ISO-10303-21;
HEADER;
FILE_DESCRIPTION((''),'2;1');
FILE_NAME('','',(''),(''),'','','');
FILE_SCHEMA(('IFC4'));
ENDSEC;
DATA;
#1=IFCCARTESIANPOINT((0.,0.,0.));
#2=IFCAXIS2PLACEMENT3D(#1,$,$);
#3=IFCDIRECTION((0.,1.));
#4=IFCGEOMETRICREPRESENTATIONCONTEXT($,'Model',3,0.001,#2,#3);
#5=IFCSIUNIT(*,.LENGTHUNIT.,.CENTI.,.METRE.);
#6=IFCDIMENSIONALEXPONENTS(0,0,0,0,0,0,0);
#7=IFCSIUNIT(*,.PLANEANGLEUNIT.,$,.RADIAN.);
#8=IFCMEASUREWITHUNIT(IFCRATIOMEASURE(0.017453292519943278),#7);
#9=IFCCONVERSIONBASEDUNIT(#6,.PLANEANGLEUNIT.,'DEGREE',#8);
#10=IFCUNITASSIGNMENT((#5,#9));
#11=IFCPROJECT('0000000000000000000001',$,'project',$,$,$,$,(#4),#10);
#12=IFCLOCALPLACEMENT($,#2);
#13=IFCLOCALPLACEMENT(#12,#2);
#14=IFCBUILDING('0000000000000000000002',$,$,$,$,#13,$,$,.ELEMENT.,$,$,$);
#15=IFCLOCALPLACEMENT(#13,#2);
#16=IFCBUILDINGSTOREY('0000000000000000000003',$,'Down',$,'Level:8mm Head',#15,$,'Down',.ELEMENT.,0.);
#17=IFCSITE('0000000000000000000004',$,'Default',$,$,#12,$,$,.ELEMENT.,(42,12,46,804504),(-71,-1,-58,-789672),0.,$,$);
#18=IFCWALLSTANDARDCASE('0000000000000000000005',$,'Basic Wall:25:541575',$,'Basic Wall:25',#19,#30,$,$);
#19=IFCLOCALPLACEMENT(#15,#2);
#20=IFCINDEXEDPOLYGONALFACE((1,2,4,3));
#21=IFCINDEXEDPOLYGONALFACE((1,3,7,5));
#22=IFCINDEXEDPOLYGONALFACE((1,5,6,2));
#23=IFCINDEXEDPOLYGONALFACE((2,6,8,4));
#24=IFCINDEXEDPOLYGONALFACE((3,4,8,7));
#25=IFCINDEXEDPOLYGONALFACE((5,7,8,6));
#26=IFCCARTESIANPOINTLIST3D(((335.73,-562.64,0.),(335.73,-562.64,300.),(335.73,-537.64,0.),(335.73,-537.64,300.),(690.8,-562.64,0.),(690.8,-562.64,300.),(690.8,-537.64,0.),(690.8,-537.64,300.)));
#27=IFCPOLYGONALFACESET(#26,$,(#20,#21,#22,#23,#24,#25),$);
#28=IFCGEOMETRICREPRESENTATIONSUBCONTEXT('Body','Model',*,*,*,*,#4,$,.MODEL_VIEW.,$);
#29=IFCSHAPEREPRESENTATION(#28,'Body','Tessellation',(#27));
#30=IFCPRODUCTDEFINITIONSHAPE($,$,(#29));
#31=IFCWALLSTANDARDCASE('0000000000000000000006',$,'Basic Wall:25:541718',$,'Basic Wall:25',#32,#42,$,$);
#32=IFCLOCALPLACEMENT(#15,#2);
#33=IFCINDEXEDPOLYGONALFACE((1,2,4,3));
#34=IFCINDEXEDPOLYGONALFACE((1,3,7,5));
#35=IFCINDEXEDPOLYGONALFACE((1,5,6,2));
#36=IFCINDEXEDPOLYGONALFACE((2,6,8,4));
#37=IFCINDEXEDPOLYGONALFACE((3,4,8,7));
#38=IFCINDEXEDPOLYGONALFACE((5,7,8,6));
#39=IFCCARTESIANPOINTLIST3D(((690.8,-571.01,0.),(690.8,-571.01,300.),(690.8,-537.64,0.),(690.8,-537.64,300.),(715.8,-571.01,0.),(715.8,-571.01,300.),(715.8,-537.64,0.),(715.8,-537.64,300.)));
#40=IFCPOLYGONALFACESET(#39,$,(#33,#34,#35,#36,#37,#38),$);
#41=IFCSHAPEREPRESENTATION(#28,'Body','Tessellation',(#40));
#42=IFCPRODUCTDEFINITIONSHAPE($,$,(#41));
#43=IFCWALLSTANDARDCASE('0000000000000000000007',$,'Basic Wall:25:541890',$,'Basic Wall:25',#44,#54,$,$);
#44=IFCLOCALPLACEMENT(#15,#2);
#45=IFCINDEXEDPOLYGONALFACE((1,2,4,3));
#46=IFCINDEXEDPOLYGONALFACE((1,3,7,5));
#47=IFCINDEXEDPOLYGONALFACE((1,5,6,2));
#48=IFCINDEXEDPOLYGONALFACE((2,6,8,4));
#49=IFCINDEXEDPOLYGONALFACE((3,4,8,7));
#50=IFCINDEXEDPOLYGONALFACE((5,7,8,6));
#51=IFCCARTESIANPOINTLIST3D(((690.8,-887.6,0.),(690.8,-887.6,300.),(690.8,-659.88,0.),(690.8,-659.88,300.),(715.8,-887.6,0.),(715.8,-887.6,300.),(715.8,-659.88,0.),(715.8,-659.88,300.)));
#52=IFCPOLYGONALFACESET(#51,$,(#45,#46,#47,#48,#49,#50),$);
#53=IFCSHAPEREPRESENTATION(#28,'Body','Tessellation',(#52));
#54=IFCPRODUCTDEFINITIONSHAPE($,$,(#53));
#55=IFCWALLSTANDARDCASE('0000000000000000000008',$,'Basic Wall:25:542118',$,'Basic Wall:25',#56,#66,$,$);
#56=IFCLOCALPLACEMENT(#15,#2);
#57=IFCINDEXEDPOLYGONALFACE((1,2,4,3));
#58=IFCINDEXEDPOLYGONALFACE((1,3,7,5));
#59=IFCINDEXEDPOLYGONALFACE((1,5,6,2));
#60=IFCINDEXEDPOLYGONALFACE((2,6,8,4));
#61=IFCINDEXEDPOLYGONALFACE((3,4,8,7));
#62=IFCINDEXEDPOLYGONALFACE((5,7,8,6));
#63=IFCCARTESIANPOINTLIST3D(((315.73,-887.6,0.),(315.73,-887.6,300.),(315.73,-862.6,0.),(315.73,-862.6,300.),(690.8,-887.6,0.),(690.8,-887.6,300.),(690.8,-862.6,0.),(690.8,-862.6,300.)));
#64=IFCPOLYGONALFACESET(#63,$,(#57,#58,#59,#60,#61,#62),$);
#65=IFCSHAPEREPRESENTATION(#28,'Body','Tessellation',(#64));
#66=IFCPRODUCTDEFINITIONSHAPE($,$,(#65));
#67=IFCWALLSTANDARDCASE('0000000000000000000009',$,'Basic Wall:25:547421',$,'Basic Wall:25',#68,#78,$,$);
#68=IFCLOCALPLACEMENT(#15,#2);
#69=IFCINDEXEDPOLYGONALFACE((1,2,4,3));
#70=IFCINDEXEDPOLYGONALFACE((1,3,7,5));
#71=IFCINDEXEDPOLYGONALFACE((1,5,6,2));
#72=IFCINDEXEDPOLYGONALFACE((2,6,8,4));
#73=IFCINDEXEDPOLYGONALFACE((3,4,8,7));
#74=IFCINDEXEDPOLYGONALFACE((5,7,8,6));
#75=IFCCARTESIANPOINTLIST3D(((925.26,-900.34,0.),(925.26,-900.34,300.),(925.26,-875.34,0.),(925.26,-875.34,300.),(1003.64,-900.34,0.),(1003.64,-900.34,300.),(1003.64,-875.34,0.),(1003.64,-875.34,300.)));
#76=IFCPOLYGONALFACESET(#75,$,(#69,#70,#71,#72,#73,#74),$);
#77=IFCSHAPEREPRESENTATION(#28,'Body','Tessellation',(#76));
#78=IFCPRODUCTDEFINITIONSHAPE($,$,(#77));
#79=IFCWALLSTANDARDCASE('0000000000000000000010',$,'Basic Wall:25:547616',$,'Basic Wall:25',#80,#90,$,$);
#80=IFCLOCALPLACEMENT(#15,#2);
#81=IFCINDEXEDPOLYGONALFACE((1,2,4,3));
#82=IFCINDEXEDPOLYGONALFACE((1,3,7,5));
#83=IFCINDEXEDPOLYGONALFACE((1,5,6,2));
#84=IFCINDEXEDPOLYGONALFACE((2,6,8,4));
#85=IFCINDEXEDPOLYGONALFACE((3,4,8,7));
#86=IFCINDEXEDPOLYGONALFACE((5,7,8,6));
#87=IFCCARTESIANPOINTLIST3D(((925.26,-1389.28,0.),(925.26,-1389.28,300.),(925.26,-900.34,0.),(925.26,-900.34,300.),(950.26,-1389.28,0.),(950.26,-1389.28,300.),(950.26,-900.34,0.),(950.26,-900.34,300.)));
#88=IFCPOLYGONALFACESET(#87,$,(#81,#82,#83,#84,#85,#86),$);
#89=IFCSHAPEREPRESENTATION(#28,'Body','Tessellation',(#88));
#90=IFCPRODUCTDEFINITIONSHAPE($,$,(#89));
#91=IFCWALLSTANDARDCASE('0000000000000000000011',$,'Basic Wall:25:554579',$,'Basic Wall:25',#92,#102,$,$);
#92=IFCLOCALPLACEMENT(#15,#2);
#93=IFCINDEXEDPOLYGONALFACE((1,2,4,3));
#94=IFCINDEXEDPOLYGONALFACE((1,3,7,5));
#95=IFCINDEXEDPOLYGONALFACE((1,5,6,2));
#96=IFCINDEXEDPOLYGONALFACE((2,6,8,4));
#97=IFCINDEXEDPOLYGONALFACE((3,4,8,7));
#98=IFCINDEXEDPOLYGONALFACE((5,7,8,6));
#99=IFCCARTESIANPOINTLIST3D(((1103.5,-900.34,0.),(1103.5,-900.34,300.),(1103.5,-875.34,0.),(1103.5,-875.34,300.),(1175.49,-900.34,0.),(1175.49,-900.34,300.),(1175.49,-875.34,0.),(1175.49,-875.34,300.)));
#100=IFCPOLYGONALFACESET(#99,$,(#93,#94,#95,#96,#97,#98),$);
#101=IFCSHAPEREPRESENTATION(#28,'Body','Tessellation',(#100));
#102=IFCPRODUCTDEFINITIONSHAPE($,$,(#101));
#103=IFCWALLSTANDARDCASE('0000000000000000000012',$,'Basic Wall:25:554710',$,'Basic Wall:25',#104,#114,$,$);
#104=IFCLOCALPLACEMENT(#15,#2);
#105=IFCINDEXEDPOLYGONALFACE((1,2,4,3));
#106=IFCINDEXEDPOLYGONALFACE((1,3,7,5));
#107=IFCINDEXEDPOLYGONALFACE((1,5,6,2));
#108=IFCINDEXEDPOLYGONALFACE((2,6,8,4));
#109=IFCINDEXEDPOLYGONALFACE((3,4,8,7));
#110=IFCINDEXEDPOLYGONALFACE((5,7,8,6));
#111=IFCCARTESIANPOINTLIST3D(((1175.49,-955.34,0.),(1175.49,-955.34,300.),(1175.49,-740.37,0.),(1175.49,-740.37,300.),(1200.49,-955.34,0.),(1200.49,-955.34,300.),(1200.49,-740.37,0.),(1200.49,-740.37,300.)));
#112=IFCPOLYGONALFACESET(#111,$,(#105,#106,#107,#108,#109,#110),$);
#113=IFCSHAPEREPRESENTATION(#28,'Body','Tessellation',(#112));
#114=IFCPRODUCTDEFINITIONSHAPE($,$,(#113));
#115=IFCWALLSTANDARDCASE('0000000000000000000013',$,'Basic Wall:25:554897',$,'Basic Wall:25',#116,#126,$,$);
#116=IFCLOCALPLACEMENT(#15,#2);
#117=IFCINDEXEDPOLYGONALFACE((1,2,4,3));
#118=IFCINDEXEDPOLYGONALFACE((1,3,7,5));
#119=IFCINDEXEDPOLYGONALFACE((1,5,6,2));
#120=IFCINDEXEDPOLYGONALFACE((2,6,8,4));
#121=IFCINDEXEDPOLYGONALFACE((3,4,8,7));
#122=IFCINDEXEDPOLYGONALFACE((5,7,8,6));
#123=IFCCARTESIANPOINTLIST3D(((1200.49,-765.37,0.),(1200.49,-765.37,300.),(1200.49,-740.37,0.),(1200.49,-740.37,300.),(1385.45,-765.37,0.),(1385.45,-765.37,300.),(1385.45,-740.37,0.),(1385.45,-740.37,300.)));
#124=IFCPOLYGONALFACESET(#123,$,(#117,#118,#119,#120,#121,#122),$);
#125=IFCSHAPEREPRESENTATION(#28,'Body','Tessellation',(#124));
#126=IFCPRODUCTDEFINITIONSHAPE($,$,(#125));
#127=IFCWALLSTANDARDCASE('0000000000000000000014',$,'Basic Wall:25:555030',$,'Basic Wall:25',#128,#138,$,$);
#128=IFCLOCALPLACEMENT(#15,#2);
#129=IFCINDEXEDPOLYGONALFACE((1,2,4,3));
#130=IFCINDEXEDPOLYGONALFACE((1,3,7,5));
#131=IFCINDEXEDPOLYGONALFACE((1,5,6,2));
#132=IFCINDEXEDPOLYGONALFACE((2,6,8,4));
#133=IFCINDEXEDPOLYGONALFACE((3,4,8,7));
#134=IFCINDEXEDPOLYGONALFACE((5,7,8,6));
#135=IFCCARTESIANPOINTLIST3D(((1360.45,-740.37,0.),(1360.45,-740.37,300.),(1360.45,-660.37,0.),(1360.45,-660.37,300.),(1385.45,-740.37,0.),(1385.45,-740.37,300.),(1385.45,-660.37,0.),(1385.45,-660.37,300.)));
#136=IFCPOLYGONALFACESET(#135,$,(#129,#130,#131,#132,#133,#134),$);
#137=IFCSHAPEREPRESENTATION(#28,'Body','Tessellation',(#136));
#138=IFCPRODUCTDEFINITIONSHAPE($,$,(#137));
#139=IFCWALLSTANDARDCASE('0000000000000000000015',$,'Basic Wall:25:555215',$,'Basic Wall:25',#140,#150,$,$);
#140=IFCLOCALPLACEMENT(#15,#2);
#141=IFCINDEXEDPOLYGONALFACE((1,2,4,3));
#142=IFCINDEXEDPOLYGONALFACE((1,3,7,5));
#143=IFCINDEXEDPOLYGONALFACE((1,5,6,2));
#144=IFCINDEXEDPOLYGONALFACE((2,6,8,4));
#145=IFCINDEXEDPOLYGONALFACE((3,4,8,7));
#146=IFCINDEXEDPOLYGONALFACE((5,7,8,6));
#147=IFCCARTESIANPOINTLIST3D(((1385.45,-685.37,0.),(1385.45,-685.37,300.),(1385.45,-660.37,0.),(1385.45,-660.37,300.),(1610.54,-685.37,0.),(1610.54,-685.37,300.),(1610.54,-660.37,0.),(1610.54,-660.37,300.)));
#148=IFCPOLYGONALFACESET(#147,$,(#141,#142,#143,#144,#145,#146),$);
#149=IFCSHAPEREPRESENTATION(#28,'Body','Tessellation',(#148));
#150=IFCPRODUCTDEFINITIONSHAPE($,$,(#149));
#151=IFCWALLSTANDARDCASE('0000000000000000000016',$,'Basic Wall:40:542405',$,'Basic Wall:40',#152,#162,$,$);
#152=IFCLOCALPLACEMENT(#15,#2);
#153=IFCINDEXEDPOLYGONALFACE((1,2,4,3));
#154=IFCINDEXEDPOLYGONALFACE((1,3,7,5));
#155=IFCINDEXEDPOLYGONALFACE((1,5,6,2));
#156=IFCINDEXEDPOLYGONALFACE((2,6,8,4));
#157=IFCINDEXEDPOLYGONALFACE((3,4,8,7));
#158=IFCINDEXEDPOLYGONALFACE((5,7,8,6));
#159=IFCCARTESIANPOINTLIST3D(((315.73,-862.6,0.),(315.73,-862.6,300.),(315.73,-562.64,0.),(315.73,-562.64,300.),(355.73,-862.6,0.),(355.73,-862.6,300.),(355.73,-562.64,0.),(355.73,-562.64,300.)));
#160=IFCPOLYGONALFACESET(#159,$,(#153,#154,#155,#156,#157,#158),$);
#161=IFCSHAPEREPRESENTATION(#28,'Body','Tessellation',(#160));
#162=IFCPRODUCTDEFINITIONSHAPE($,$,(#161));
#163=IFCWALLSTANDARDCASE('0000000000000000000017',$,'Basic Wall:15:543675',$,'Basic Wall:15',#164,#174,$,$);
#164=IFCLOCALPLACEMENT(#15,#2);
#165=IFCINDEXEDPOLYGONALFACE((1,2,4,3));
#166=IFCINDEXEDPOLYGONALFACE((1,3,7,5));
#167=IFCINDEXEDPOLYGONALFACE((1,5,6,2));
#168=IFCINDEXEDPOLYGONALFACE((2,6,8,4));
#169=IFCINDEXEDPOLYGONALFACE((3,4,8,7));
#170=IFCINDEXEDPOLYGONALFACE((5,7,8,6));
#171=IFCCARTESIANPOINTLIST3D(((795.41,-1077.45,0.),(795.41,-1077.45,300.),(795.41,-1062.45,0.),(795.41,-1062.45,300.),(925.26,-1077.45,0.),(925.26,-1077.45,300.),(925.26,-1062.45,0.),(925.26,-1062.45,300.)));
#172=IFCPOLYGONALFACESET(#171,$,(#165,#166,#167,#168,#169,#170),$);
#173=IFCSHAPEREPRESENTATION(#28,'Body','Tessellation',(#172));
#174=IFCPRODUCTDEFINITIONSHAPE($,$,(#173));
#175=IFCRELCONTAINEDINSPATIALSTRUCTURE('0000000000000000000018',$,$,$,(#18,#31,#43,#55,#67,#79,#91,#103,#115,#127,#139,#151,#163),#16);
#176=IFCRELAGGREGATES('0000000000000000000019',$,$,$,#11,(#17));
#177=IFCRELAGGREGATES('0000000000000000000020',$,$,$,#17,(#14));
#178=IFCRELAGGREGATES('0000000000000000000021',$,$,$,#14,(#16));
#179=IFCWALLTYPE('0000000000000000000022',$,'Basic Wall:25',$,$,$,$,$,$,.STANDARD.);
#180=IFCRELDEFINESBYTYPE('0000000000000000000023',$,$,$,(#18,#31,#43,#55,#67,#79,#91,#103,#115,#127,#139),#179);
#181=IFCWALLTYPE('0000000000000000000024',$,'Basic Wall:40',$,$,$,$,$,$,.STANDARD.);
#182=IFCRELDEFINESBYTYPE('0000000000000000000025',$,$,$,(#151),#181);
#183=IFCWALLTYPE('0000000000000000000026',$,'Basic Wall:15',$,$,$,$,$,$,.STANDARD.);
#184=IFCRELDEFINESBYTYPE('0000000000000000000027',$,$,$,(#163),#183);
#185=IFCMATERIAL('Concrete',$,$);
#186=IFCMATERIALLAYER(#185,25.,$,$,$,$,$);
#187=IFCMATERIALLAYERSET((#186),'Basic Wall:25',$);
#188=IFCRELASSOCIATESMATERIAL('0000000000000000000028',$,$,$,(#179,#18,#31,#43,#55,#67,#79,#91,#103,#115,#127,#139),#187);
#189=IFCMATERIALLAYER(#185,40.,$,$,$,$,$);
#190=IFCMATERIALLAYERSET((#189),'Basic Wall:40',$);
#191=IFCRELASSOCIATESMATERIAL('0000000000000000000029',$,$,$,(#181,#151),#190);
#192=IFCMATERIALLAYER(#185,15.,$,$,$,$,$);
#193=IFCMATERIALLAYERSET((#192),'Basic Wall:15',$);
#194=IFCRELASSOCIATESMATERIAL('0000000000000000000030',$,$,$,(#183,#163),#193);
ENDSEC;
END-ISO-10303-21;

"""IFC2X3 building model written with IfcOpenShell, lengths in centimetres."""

from ifc_helpers import new_model, entity, si_unit, converted_unit, direction, frame, frame_2d, origin, place, context, subcontext, project, spatial, rectangle, extrude, material, layer, layer_set, layer_usage, type_object, element, save


model = new_model("IFC2X3")

# Units and contexts
model_context = context("Model", 3, precision=0.001, world=origin(), true_north=direction((0.0, 1.0)))
body_context = subcontext(model_context, "Body", "Model", "MODEL_VIEW")
ifc_project = project(units=[si_unit("LENGTHUNIT", "METRE", prefix="CENTI"), converted_unit("PLANEANGLEUNIT", "DEGREE", entity("IfcRatioMeasure", 0.017453292519943278), si_unit("PLANEANGLEUNIT", "RADIAN"), dimensions=[0, 0, 0, 0, 0, 0, 0])], contexts=[model_context])

# Site, building, storey
site_placement = place(None, origin())
site = spatial("IfcSite", under=ifc_project, at=site_placement, Name="Default", CompositionType="ELEMENT", RefLatitude=(42, 12, 46, 804504), RefLongitude=(-71, -1, -58, -789672), RefElevation=0.0)
building_placement = place(site_placement, origin())
building = spatial("IfcBuilding", under=site, at=building_placement, CompositionType="ELEMENT")
storey_placement = place(building_placement, origin())
storey = spatial("IfcBuildingStorey", under=building, at=storey_placement, Name="Down", ObjectType="Level:8mm Head", LongName="Down", CompositionType="ELEMENT", Elevation=0.0)

# Walls
ifc_material = material(Name="Concrete")
ifc_layer_1 = layer(ifc_material, 25.0)
ifc_layer_set_1 = layer_set([ifc_layer_1], Name="Basic Wall:25")
ifc_layer_usage_1 = layer_usage(ifc_layer_set_1, "AXIS2", "POSITIVE", -12.5)
wall_type_1 = type_object("IfcWallType", Name="Basic Wall:25", PredefinedType="STANDARD", material=ifc_layer_set_1)
wall_1_placement = place(storey_placement, frame((690.8, -550.14, 0.0), z_axis=(0.0, 0.0, 1.0), x_axis=(-1.0, 0.0, 0.0)))
element("IfcWallStandardCase", 1, at=wall_1_placement, inside=storey, type_object=wall_type_1, material=ifc_layer_usage_1, Name="Basic Wall:25:541575", ObjectType="Basic Wall:25", context=body_context, shape_type="SweptSolid", body=[
    extrude(rectangle(XDim=355.06, YDim=25.0, at=frame_2d((177.53, 0.0), x_axis=(-1.0, 0.0))), origin(), (0.0, 0.0, 1.0), 300.0),
])
ifc_layer_usage_2 = layer_usage(ifc_layer_set_1, "AXIS2", "NEGATIVE", 12.5)
wall_2_placement = place(storey_placement, frame((703.3, -537.64, 0.0), z_axis=(0.0, 0.0, 1.0), x_axis=(0.0, -1.0, 0.0)))
element("IfcWallStandardCase", 2, at=wall_2_placement, inside=storey, type_object=wall_type_1, material=ifc_layer_usage_2, Name="Basic Wall:25:541718", ObjectType="Basic Wall:25", context=body_context, shape_type="SweptSolid", body=[
    extrude(rectangle(XDim=33.37, YDim=25.0, at=frame_2d((16.68, 0.0), x_axis=(-1.0, 0.0))), origin(), (0.0, 0.0, 1.0), 300.0),
])
ifc_layer_usage_3 = layer_usage(ifc_layer_set_1, "AXIS2", "NEGATIVE", 12.5)
wall_3_placement = place(storey_placement, frame((703.3, -659.88, 0.0), z_axis=(0.0, 0.0, 1.0), x_axis=(0.0, -1.0, 0.0)))
element("IfcWallStandardCase", 3, at=wall_3_placement, inside=storey, type_object=wall_type_1, material=ifc_layer_usage_3, Name="Basic Wall:25:541890", ObjectType="Basic Wall:25", context=body_context, shape_type="SweptSolid", body=[
    extrude(rectangle(XDim=227.72, YDim=25.0, at=frame_2d((113.86, 0.0), x_axis=(-1.0, 0.0))), origin(), (0.0, 0.0, 1.0), 300.0),
])
ifc_layer_usage_4 = layer_usage(ifc_layer_set_1, "AXIS2", "NEGATIVE", 12.5)
wall_4_placement = place(storey_placement, frame((690.8, -875.1, 0.0), z_axis=(0.0, 0.0, 1.0), x_axis=(-1.0, 0.0, 0.0)))
element("IfcWallStandardCase", 4, at=wall_4_placement, inside=storey, type_object=wall_type_1, material=ifc_layer_usage_4, Name="Basic Wall:25:542118", ObjectType="Basic Wall:25", context=body_context, shape_type="SweptSolid", body=[
    extrude(rectangle(XDim=375.06, YDim=25.0, at=frame_2d((187.53, 0.0), x_axis=(-1.0, 0.0))), origin(), (0.0, 0.0, 1.0), 300.0),
])
ifc_layer_usage_5 = layer_usage(ifc_layer_set_1, "AXIS2", "POSITIVE", -12.5)
wall_5_placement = place(storey_placement, frame((1003.64, -887.84, 0.0), z_axis=(0.0, 0.0, 1.0), x_axis=(-1.0, 0.0, 0.0)))
element("IfcWallStandardCase", 5, at=wall_5_placement, inside=storey, type_object=wall_type_1, material=ifc_layer_usage_5, Name="Basic Wall:25:547421", ObjectType="Basic Wall:25", context=body_context, shape_type="SweptSolid", body=[
    extrude(rectangle(XDim=78.38, YDim=25.0, at=frame_2d((39.19, 0.0), x_axis=(-1.0, 0.0))), origin(), (0.0, 0.0, 1.0), 300.0),
])
ifc_layer_usage_6 = layer_usage(ifc_layer_set_1, "AXIS2", "POSITIVE", -12.5)
wall_6_placement = place(storey_placement, frame((937.76, -900.34, 0.0), z_axis=(0.0, 0.0, 1.0), x_axis=(0.0, -1.0, 0.0)))
element("IfcWallStandardCase", 6, at=wall_6_placement, inside=storey, type_object=wall_type_1, material=ifc_layer_usage_6, Name="Basic Wall:25:547616", ObjectType="Basic Wall:25", context=body_context, shape_type="SweptSolid", body=[
    extrude(rectangle(XDim=488.94, YDim=25.0, at=frame_2d((244.47, 0.0), x_axis=(-1.0, 0.0))), origin(), (0.0, 0.0, 1.0), 300.0),
])
ifc_layer_usage_7 = layer_usage(ifc_layer_set_1, "AXIS2", "NEGATIVE", 12.5)
wall_7_placement = place(storey_placement, frame((1103.5, -887.84, 0.0)))
element("IfcWallStandardCase", 7, at=wall_7_placement, inside=storey, type_object=wall_type_1, material=ifc_layer_usage_7, Name="Basic Wall:25:554579", ObjectType="Basic Wall:25", context=body_context, shape_type="SweptSolid", body=[
    extrude(rectangle(XDim=71.99, YDim=25.0, at=frame_2d((36.0, 0.0), x_axis=(-1.0, 0.0))), origin(), (0.0, 0.0, 1.0), 300.0),
])
ifc_layer_usage_8 = layer_usage(ifc_layer_set_1, "AXIS2", "NEGATIVE", 12.5)
wall_8_placement = place(storey_placement, frame((1187.99, -955.34, 0.0), z_axis=(0.0, 0.0, 1.0), x_axis=(0.0, 1.0, 0.0)))
element("IfcWallStandardCase", 8, at=wall_8_placement, inside=storey, type_object=wall_type_1, material=ifc_layer_usage_8, Name="Basic Wall:25:554710", ObjectType="Basic Wall:25", context=body_context, shape_type="SweptSolid", body=[
    extrude(rectangle(XDim=214.97, YDim=25.0, at=frame_2d((107.49, 0.0), x_axis=(-1.0, 0.0))), origin(), (0.0, 0.0, 1.0), 300.0),
])
ifc_layer_usage_9 = layer_usage(ifc_layer_set_1, "AXIS2", "NEGATIVE", 12.5)
wall_9_placement = place(storey_placement, frame((1200.49, -752.87, 0.0)))
element("IfcWallStandardCase", 9, at=wall_9_placement, inside=storey, type_object=wall_type_1, material=ifc_layer_usage_9, Name="Basic Wall:25:554897", ObjectType="Basic Wall:25", context=body_context, shape_type="SweptSolid", body=[
    extrude(rectangle(XDim=184.96, YDim=25.0, at=frame_2d((92.48, 0.0), x_axis=(-1.0, 0.0))), origin(), (0.0, 0.0, 1.0), 300.0),
])
ifc_layer_usage_10 = layer_usage(ifc_layer_set_1, "AXIS2", "POSITIVE", -12.5)
wall_10_placement = place(storey_placement, frame((1372.95, -740.37, 0.0), z_axis=(0.0, 0.0, 1.0), x_axis=(0.0, 1.0, 0.0)))
element("IfcWallStandardCase", 10, at=wall_10_placement, inside=storey, type_object=wall_type_1, material=ifc_layer_usage_10, Name="Basic Wall:25:555030", ObjectType="Basic Wall:25", context=body_context, shape_type="SweptSolid", body=[
    extrude(rectangle(XDim=80.0, YDim=25.0, at=frame_2d((40.0, 0.0), x_axis=(-1.0, 0.0))), origin(), (0.0, 0.0, 1.0), 300.0),
])
ifc_layer_usage_11 = layer_usage(ifc_layer_set_1, "AXIS2", "NEGATIVE", 12.5)
wall_11_placement = place(storey_placement, frame((1385.45, -672.87, 0.0)))
element("IfcWallStandardCase", 11, at=wall_11_placement, inside=storey, type_object=wall_type_1, material=ifc_layer_usage_11, Name="Basic Wall:25:555215", ObjectType="Basic Wall:25", context=body_context, shape_type="SweptSolid", body=[
    extrude(rectangle(XDim=225.09, YDim=25.0, at=frame_2d((112.55, 0.0), x_axis=(-1.0, 0.0))), origin(), (0.0, 0.0, 1.0), 300.0),
])
ifc_layer_2 = layer(ifc_material, 40.0)
ifc_layer_set_2 = layer_set([ifc_layer_2], Name="Basic Wall:40")
ifc_layer_usage_12 = layer_usage(ifc_layer_set_2, "AXIS2", "NEGATIVE", 20.0)
wall_type_2 = type_object("IfcWallType", Name="Basic Wall:40", PredefinedType="STANDARD", material=ifc_layer_set_2)
wall_12_placement = place(storey_placement, frame((335.73, -862.6, 0.0), z_axis=(0.0, 0.0, 1.0), x_axis=(0.0, 1.0, 0.0)))
element("IfcWallStandardCase", 12, at=wall_12_placement, inside=storey, type_object=wall_type_2, material=ifc_layer_usage_12, Name="Basic Wall:40:542405", ObjectType="Basic Wall:40", context=body_context, shape_type="SweptSolid", body=[
    extrude(rectangle(XDim=299.96, YDim=40.0, at=frame_2d((149.98, 0.0), x_axis=(-1.0, 0.0))), origin(), (0.0, 0.0, 1.0), 300.0),
])
ifc_layer_3 = layer(ifc_material, 15.0)
ifc_layer_set_3 = layer_set([ifc_layer_3], Name="Basic Wall:15")
ifc_layer_usage_13 = layer_usage(ifc_layer_set_3, "AXIS2", "POSITIVE", -7.5)
wall_type_3 = type_object("IfcWallType", Name="Basic Wall:15", PredefinedType="STANDARD", material=ifc_layer_set_3)
wall_13_placement = place(storey_placement, frame((795.41, -1069.95, 0.0)))
element("IfcWallStandardCase", 13, at=wall_13_placement, inside=storey, type_object=wall_type_3, material=ifc_layer_usage_13, Name="Basic Wall:15:543675", ObjectType="Basic Wall:15", context=body_context, shape_type="SweptSolid", body=[
    extrude(rectangle(XDim=129.86, YDim=15.0, at=frame_2d((64.93, 0.0), x_axis=(-1.0, 0.0))), origin(), (0.0, 0.0, 1.0), 300.0),
])

save(model, "model.ifc")
